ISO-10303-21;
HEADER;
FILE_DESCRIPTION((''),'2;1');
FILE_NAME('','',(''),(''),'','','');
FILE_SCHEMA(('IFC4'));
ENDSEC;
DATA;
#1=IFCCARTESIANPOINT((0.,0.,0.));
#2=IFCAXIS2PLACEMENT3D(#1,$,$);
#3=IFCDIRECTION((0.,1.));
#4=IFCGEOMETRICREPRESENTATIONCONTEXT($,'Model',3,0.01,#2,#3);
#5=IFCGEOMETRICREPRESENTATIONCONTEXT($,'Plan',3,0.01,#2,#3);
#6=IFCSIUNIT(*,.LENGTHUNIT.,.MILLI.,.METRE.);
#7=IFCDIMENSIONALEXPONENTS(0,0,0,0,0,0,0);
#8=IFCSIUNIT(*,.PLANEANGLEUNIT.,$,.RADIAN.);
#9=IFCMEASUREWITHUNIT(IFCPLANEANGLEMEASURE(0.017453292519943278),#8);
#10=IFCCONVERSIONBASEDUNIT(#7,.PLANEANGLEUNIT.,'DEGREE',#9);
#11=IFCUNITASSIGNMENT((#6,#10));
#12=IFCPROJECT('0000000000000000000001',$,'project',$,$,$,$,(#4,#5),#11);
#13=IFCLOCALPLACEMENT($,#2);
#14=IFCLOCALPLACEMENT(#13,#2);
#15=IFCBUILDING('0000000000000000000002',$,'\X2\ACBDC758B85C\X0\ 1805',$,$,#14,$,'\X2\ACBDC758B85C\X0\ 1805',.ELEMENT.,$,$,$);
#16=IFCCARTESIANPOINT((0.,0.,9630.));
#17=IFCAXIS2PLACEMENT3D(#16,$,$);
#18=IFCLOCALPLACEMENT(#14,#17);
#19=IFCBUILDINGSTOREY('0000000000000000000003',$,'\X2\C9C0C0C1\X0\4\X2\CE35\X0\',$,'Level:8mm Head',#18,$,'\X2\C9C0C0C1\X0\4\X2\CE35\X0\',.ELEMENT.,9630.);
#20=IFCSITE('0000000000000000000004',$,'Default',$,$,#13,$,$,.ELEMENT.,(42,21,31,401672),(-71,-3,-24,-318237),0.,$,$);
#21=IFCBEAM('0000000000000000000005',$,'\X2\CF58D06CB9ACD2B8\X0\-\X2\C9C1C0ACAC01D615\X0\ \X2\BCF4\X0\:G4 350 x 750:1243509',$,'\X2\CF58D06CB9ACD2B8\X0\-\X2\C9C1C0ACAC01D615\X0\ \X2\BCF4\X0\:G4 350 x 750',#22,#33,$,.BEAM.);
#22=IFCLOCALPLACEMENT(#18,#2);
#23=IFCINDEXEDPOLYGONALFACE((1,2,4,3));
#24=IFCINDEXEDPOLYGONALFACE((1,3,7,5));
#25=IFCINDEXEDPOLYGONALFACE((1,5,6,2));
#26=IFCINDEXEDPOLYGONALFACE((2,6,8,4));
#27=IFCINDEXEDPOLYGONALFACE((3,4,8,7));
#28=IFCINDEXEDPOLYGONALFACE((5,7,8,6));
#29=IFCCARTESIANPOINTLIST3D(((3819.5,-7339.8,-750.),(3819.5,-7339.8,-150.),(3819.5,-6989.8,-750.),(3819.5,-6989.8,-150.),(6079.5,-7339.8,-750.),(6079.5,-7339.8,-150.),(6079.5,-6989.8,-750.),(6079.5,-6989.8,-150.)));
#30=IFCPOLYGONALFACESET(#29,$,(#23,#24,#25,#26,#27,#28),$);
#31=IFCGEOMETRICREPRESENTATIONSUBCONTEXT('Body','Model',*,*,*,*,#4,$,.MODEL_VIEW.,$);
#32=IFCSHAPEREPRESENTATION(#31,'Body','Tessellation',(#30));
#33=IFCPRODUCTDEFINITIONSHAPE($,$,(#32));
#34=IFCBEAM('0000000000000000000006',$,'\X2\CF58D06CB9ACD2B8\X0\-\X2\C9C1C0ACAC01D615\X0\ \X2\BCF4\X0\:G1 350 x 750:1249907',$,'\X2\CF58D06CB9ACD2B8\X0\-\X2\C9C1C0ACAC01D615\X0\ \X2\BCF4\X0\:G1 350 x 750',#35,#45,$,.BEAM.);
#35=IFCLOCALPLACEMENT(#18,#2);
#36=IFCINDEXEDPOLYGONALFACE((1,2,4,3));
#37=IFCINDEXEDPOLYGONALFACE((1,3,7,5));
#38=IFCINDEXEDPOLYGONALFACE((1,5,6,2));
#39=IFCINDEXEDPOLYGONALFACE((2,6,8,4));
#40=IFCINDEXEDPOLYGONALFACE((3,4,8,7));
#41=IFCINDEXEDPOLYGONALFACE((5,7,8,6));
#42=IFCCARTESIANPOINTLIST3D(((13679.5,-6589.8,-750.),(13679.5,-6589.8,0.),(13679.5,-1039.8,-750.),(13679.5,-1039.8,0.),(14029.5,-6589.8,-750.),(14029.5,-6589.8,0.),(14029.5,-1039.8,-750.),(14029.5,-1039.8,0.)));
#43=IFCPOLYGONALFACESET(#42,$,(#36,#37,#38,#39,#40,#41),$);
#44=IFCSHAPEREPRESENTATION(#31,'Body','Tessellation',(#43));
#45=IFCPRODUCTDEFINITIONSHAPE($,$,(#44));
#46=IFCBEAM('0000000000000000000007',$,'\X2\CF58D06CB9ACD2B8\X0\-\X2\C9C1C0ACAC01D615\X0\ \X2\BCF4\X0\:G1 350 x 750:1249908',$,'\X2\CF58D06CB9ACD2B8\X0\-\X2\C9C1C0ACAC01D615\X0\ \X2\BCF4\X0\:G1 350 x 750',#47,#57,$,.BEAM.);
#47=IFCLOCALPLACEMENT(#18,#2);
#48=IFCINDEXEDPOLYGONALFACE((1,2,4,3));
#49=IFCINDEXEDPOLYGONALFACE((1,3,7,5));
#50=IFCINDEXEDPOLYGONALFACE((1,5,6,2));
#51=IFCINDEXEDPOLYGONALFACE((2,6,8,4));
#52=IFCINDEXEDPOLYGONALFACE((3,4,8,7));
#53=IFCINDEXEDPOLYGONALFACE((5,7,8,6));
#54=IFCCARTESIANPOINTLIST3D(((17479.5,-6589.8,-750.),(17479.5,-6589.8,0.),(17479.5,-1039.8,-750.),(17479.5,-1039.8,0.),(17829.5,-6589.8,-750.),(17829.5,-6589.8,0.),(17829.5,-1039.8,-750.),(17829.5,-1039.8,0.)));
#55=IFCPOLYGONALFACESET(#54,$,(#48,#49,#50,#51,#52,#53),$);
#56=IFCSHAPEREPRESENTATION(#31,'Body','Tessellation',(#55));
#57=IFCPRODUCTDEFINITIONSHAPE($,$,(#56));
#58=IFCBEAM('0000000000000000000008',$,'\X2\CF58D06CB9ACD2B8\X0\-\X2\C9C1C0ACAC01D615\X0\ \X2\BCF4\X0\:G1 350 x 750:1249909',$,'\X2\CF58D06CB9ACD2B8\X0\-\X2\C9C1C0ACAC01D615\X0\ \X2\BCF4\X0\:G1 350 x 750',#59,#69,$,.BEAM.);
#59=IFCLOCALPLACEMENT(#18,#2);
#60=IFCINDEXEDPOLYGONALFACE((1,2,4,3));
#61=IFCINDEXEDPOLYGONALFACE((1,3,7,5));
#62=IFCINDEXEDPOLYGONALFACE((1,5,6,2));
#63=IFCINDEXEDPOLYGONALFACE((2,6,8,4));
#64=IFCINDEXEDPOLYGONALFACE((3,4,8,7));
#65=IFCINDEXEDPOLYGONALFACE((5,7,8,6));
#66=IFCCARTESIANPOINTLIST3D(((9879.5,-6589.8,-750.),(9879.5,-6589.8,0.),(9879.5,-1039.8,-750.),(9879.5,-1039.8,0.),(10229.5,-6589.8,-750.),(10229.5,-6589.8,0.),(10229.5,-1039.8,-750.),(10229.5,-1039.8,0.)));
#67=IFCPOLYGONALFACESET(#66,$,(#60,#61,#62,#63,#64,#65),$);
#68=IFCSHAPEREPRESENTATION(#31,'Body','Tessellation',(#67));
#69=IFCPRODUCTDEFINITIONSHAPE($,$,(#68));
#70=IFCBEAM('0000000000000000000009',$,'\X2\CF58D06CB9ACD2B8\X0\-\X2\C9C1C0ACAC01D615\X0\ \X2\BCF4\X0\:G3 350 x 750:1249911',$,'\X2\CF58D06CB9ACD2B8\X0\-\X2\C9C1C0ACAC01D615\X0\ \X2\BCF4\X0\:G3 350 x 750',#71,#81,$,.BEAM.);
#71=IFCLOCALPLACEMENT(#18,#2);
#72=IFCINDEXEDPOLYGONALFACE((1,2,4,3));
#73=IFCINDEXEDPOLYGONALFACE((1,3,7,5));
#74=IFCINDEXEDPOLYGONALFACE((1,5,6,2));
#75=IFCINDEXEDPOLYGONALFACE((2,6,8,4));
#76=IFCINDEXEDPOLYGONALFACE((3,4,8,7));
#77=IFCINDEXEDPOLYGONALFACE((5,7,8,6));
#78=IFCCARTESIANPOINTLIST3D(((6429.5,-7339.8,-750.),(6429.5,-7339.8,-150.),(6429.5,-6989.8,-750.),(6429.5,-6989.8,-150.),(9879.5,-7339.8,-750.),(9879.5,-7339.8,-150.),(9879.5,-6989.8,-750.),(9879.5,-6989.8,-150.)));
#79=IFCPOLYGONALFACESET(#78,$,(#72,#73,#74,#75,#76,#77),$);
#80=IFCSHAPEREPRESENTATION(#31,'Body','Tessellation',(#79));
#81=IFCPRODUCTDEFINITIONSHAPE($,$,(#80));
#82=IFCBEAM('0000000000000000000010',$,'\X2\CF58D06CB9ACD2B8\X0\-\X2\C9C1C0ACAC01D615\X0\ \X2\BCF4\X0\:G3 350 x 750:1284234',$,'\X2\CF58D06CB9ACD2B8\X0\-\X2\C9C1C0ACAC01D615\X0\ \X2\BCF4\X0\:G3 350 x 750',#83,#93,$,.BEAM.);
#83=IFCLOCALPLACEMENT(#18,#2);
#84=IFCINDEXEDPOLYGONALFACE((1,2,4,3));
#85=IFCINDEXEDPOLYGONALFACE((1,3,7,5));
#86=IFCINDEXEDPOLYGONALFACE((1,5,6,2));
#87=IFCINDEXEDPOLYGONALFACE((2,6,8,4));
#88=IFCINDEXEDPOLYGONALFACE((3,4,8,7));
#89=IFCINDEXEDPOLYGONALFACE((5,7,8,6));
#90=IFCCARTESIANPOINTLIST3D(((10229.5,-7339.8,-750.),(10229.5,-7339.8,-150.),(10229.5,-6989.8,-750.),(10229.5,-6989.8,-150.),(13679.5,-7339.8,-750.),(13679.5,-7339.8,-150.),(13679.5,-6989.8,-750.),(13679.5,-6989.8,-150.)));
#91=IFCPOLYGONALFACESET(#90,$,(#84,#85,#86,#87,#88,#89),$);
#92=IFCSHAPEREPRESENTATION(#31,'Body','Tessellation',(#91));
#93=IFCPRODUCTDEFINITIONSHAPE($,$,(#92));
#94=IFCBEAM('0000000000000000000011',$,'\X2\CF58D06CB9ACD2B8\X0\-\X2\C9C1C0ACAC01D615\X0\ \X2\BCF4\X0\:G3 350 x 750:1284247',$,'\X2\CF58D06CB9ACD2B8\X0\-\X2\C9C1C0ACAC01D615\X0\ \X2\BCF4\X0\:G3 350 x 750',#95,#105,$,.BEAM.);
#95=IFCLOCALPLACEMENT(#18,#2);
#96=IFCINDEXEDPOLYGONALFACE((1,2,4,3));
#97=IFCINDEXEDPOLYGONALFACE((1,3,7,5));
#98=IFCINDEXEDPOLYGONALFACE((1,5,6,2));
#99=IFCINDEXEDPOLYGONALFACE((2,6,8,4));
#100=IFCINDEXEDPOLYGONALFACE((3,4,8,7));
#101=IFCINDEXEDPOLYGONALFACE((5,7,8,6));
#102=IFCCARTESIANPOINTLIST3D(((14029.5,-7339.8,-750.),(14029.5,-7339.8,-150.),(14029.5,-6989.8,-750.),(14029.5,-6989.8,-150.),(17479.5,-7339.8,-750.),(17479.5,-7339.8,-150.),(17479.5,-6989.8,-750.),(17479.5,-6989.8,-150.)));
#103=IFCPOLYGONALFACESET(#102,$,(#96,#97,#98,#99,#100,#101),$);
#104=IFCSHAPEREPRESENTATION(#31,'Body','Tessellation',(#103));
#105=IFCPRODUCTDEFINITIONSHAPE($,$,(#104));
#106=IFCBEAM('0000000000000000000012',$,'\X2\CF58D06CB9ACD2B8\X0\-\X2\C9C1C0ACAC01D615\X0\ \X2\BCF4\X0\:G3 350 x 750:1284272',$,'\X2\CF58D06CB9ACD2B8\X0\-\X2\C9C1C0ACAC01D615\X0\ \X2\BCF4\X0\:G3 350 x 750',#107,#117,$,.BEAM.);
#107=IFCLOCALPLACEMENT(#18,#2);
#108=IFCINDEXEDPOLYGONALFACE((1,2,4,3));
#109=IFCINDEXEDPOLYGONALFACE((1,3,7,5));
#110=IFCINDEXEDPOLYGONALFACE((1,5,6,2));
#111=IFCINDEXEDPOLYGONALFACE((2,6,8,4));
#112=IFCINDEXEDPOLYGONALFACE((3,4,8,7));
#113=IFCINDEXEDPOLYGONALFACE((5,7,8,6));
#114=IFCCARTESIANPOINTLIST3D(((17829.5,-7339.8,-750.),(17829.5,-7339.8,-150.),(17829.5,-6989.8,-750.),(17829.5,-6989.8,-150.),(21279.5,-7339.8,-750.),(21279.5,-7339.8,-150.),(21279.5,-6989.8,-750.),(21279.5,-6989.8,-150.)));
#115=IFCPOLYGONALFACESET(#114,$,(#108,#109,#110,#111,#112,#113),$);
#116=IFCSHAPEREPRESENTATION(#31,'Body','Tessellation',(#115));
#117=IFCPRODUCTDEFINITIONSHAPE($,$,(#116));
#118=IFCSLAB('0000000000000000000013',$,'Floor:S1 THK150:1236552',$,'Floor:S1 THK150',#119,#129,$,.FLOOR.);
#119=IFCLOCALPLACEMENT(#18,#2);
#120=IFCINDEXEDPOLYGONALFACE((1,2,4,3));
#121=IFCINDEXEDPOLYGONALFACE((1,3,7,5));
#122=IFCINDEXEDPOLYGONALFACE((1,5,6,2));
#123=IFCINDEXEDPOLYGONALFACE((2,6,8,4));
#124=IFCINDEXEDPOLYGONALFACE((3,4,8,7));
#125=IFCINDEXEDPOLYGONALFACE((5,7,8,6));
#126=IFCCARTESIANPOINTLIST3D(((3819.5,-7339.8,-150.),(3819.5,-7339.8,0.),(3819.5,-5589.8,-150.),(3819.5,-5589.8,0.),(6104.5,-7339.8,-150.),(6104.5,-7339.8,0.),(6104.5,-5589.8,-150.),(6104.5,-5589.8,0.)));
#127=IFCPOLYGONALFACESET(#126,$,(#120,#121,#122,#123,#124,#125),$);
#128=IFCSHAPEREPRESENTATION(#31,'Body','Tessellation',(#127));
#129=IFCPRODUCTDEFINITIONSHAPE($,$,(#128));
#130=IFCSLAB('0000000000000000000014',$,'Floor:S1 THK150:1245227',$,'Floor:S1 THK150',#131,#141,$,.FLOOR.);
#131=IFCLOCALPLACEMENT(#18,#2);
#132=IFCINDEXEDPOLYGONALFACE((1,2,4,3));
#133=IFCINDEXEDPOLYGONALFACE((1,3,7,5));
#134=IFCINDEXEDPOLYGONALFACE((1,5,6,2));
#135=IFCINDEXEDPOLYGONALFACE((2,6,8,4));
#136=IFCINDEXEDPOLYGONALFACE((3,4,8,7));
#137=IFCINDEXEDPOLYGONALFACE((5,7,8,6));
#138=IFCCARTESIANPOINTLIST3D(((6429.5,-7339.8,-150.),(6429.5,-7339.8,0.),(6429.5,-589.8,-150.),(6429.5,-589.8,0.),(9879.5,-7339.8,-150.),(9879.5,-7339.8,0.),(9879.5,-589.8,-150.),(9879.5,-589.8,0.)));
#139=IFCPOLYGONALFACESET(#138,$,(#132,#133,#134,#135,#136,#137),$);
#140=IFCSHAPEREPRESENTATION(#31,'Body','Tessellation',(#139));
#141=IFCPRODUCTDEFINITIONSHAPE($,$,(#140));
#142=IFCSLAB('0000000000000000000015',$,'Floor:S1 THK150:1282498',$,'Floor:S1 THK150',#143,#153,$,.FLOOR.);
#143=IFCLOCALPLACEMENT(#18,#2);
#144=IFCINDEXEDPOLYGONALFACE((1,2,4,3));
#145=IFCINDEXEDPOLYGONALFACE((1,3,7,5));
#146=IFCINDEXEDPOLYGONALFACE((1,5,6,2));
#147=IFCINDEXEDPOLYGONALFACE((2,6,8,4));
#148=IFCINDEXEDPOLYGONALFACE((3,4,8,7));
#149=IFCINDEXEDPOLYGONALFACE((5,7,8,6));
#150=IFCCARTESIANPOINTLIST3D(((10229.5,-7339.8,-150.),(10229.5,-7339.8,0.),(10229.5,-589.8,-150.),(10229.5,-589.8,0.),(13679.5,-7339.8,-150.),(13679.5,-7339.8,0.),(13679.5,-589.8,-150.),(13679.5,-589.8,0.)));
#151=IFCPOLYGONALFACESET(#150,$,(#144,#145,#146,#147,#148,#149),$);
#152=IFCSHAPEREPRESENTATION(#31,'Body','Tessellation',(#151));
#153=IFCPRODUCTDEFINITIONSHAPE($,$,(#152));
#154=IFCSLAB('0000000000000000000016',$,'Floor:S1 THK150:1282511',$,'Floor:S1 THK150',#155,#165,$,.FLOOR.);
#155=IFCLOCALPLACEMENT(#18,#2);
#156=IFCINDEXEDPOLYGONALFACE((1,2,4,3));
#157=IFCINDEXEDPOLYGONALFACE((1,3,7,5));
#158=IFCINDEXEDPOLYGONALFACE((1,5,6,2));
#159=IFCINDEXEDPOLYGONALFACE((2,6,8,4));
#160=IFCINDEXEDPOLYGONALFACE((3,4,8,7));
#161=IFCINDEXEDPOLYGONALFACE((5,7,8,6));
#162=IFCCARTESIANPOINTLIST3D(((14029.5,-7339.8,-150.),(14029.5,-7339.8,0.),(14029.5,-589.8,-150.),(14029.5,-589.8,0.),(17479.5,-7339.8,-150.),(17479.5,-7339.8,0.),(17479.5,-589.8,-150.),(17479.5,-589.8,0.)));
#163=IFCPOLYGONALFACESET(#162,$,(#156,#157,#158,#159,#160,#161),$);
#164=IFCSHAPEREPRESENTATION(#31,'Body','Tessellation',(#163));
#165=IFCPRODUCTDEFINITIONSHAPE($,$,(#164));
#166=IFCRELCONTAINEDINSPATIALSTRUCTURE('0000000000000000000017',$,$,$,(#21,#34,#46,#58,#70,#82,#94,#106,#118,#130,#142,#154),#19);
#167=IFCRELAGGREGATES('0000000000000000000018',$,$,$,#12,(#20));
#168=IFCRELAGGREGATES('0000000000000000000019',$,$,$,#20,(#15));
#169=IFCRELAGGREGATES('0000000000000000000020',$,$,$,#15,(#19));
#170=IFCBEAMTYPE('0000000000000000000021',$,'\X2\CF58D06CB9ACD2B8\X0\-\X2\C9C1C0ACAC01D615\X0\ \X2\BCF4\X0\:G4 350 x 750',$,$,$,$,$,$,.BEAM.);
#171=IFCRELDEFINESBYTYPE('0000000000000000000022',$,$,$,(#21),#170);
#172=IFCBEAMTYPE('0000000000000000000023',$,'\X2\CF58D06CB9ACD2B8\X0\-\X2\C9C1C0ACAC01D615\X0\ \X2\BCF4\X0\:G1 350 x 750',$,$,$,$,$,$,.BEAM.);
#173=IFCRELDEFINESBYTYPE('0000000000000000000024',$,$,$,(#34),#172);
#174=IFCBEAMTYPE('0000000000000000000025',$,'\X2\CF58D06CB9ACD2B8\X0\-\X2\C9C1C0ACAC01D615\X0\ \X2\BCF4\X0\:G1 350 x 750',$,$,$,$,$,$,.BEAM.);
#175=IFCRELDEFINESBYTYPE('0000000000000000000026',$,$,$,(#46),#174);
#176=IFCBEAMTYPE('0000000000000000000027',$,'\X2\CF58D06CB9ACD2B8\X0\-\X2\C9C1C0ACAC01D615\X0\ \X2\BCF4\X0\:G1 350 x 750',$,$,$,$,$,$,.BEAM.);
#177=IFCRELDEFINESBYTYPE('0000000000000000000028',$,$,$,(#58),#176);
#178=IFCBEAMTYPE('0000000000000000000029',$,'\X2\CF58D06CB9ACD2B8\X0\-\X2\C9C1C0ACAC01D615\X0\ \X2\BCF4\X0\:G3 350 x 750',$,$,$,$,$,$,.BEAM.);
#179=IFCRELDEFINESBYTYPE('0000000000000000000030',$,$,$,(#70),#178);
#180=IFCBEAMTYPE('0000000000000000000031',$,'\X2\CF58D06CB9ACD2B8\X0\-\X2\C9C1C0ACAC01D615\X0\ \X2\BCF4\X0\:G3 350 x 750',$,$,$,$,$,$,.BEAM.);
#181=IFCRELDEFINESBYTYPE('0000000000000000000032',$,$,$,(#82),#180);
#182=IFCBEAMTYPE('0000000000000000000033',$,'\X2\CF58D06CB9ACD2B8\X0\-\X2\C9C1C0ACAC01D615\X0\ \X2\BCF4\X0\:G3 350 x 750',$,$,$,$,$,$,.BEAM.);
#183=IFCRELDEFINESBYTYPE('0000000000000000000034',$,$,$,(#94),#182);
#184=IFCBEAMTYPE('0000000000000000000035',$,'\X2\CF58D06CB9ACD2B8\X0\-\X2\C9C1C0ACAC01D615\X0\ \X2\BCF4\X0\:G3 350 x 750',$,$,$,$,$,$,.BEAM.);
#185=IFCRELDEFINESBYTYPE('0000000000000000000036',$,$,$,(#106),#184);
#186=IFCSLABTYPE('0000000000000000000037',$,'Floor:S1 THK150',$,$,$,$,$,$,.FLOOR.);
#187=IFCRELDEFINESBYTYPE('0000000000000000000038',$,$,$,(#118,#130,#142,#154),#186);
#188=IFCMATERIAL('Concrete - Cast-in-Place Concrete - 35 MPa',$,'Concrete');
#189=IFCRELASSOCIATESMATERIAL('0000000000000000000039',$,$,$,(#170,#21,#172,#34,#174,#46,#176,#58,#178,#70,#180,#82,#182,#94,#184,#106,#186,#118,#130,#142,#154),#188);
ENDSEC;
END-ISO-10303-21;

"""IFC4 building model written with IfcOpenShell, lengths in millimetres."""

from ifc_helpers import new_model, entity, si_unit, converted_unit, direction, frame, origin, place, context, subcontext, project, spatial, indexed_curve, outline, extrude, source, transform, mapped, material, type_object, type_shapes, element, save


model = new_model("IFC4")

# Units and contexts
model_context = context("Model", 3, precision=0.01, world=origin(), true_north=direction((0.0, 1.0)))
plan_context = context("Plan", 3, precision=0.01, world=origin(), true_north=direction((0.0, 1.0)))
body_context = subcontext(model_context, "Body", "Model", "MODEL_VIEW")
ifc_project = project(units=[si_unit("LENGTHUNIT", "METRE", prefix="MILLI"), converted_unit("PLANEANGLEUNIT", "DEGREE", entity("IfcPlaneAngleMeasure", 0.017453292519943278), si_unit("PLANEANGLEUNIT", "RADIAN"), dimensions=[0, 0, 0, 0, 0, 0, 0])], contexts=[model_context, plan_context])

# Site, building, storey
site_placement = place(None, origin())
site = spatial("IfcSite", under=ifc_project, at=site_placement, Name="Default", CompositionType="ELEMENT", RefLatitude=(42, 21, 31, 401672), RefLongitude=(-71, -3, -24, -318237), RefElevation=0.0)
building_placement = place(site_placement, origin())
building = spatial("IfcBuilding", under=site, at=building_placement, Name="경의로 1805", LongName="경의로 1805", CompositionType="ELEMENT")
storey_placement = place(building_placement, frame((0.0, 0.0, 9630.0)))
storey = spatial("IfcBuildingStorey", under=building, at=storey_placement, Name="지상4층", ObjectType="Level:8mm Head", LongName="지상4층", CompositionType="ELEMENT", Elevation=9630.0)

# Beams
ifc_material_1 = material(Name="Concrete - Cast-in-Place Concrete - 35 MPa", Category="Concrete")
beam_type_1 = type_object("IfcBeamType", Name="콘크리트-직사각형 보:G4 350 x 750", PredefinedType="BEAM", material=ifc_material_1)
shared_shape_1 = source(origin(), body_context, "Body", "SweptSolid", [
    extrude(outline(indexed_curve([(-300.0, -175.0), (300.0, -175.0), (300.0, 175.0), (-300.0, 175.0), (-300.0, -175.0)], self_intersect=False)), frame((3819.5, -7164.8, 9180.0), z_axis=(1.0, 0.0, 0.0), x_axis=(0.0, 0.0, -1.0)), (0.0, 0.0, 1.0), 2260.0),
])
type_shapes(beam_type_1, [shared_shape_1])
beam_1_placement = place(storey_placement, frame((0.0, 0.0, -9630.0)))
element("IfcBeam", 1, at=beam_1_placement, inside=storey, type_object=beam_type_1, material=ifc_material_1, Name="콘크리트-직사각형 보:G4 350 x 750:1243509", ObjectType="콘크리트-직사각형 보:G4 350 x 750", PredefinedType="BEAM", context=body_context, shape_type="MappedRepresentation", body=[
    mapped(shared_shape_1, transform((0.0, 0.0, 0.0), scale=1.0)),
])
beam_type_2 = type_object("IfcBeamType", Name="콘크리트-직사각형 보:G1 350 x 750", PredefinedType="BEAM", material=ifc_material_1)
shared_shape_2 = source(origin(), body_context, "Body", "SweptSolid", [
    extrude(outline(indexed_curve([(-175.0, -375.0), (175.0, -375.0), (175.0, 375.0), (-175.0, 375.0), (-175.0, -375.0)], self_intersect=False)), frame((13854.5, -1039.8, 9255.0), z_axis=(0.0, -1.0, 0.0), x_axis=(-1.0, 0.0, 0.0)), (0.0, 0.0, 1.0), 5550.0),
])
type_shapes(beam_type_2, [shared_shape_2])
beam_2_placement = place(storey_placement, frame((0.0, 0.0, -9630.0)))
element("IfcBeam", 2, at=beam_2_placement, inside=storey, type_object=beam_type_2, material=ifc_material_1, Name="콘크리트-직사각형 보:G1 350 x 750:1249907", ObjectType="콘크리트-직사각형 보:G1 350 x 750", PredefinedType="BEAM", context=body_context, shape_type="MappedRepresentation", body=[
    mapped(shared_shape_2, transform((0.0, 0.0, 0.0), scale=1.0)),
])
beam_type_3 = type_object("IfcBeamType", Name="콘크리트-직사각형 보:G1 350 x 750", PredefinedType="BEAM", material=ifc_material_1)
shared_shape_3 = source(origin(), body_context, "Body", "SweptSolid", [
    extrude(outline(indexed_curve([(-175.0, -375.0), (175.0, -375.0), (175.0, 375.0), (-175.0, 375.0), (-175.0, -375.0)], self_intersect=False)), frame((17654.5, -1039.8, 9255.0), z_axis=(0.0, -1.0, 0.0), x_axis=(-1.0, 0.0, 0.0)), (0.0, 0.0, 1.0), 5550.0),
])
type_shapes(beam_type_3, [shared_shape_3])
beam_3_placement = place(storey_placement, frame((0.0, 0.0, -9630.0)))
element("IfcBeam", 3, at=beam_3_placement, inside=storey, type_object=beam_type_3, material=ifc_material_1, Name="콘크리트-직사각형 보:G1 350 x 750:1249908", ObjectType="콘크리트-직사각형 보:G1 350 x 750", PredefinedType="BEAM", context=body_context, shape_type="MappedRepresentation", body=[
    mapped(shared_shape_3, transform((0.0, 0.0, 0.0), scale=1.0)),
])
beam_type_4 = type_object("IfcBeamType", Name="콘크리트-직사각형 보:G1 350 x 750", PredefinedType="BEAM", material=ifc_material_1)
shared_shape_4 = source(origin(), body_context, "Body", "SweptSolid", [
    extrude(outline(indexed_curve([(-175.0, -375.0), (175.0, -375.0), (175.0, 375.0), (-175.0, 375.0), (-175.0, -375.0)], self_intersect=False)), frame((10054.5, -1039.8, 9255.0), z_axis=(0.0, -1.0, 0.0), x_axis=(-1.0, 0.0, 0.0)), (0.0, 0.0, 1.0), 5550.0),
])
type_shapes(beam_type_4, [shared_shape_4])
beam_4_placement = place(storey_placement, frame((0.0, 0.0, -9630.0)))
element("IfcBeam", 4, at=beam_4_placement, inside=storey, type_object=beam_type_4, material=ifc_material_1, Name="콘크리트-직사각형 보:G1 350 x 750:1249909", ObjectType="콘크리트-직사각형 보:G1 350 x 750", PredefinedType="BEAM", context=body_context, shape_type="MappedRepresentation", body=[
    mapped(shared_shape_4, transform((0.0, 0.0, 0.0), scale=1.0)),
])
beam_type_5 = type_object("IfcBeamType", Name="콘크리트-직사각형 보:G3 350 x 750", PredefinedType="BEAM", material=ifc_material_1)
shared_shape_5 = source(origin(), body_context, "Body", "SweptSolid", [
    extrude(outline(indexed_curve([(-300.0, -175.0), (300.0, -175.0), (300.0, 175.0), (-300.0, 175.0), (-300.0, -175.0)], self_intersect=False)), frame((6429.5, -7164.8, 9180.0), z_axis=(1.0, 0.0, 0.0), x_axis=(0.0, 0.0, -1.0)), (0.0, 0.0, 1.0), 3450.0),
])
type_shapes(beam_type_5, [shared_shape_5])
beam_5_placement = place(storey_placement, frame((0.0, 0.0, -9630.0)))
element("IfcBeam", 5, at=beam_5_placement, inside=storey, type_object=beam_type_5, material=ifc_material_1, Name="콘크리트-직사각형 보:G3 350 x 750:1249911", ObjectType="콘크리트-직사각형 보:G3 350 x 750", PredefinedType="BEAM", context=body_context, shape_type="MappedRepresentation", body=[
    mapped(shared_shape_5, transform((0.0, 0.0, 0.0), scale=1.0)),
])
beam_type_6 = type_object("IfcBeamType", Name="콘크리트-직사각형 보:G3 350 x 750", PredefinedType="BEAM", material=ifc_material_1)
shared_shape_6 = source(origin(), body_context, "Body", "SweptSolid", [
    extrude(outline(indexed_curve([(-300.0, -175.0), (300.0, -175.0), (300.0, 175.0), (-300.0, 175.0), (-300.0, -175.0)], self_intersect=False)), frame((10229.5, -7164.8, 9180.0), z_axis=(1.0, 0.0, 0.0), x_axis=(0.0, 0.0, -1.0)), (0.0, 0.0, 1.0), 3450.0),
])
type_shapes(beam_type_6, [shared_shape_6])
beam_6_placement = place(storey_placement, frame((0.0, 0.0, -9630.0)))
element("IfcBeam", 6, at=beam_6_placement, inside=storey, type_object=beam_type_6, material=ifc_material_1, Name="콘크리트-직사각형 보:G3 350 x 750:1284234", ObjectType="콘크리트-직사각형 보:G3 350 x 750", PredefinedType="BEAM", context=body_context, shape_type="MappedRepresentation", body=[
    mapped(shared_shape_6, transform((0.0, 0.0, 0.0), scale=1.0)),
])
beam_type_7 = type_object("IfcBeamType", Name="콘크리트-직사각형 보:G3 350 x 750", PredefinedType="BEAM", material=ifc_material_1)
shared_shape_7 = source(origin(), body_context, "Body", "SweptSolid", [
    extrude(outline(indexed_curve([(-300.0, -175.0), (300.0, -175.0), (300.0, 175.0), (-300.0, 175.0), (-300.0, -175.0)], self_intersect=False)), frame((14029.5, -7164.8, 9180.0), z_axis=(1.0, 0.0, 0.0), x_axis=(0.0, 0.0, -1.0)), (0.0, 0.0, 1.0), 3450.0),
])
type_shapes(beam_type_7, [shared_shape_7])
beam_7_placement = place(storey_placement, frame((0.0, 0.0, -9630.0)))
element("IfcBeam", 7, at=beam_7_placement, inside=storey, type_object=beam_type_7, material=ifc_material_1, Name="콘크리트-직사각형 보:G3 350 x 750:1284247", ObjectType="콘크리트-직사각형 보:G3 350 x 750", PredefinedType="BEAM", context=body_context, shape_type="MappedRepresentation", body=[
    mapped(shared_shape_7, transform((0.0, 0.0, 0.0), scale=1.0)),
])
beam_type_8 = type_object("IfcBeamType", Name="콘크리트-직사각형 보:G3 350 x 750", PredefinedType="BEAM", material=ifc_material_1)
shared_shape_8 = source(origin(), body_context, "Body", "SweptSolid", [
    extrude(outline(indexed_curve([(-300.0, -175.0), (300.0, -175.0), (300.0, 175.0), (-300.0, 175.0), (-300.0, -175.0)], self_intersect=False)), frame((17829.5, -7164.8, 9180.0), z_axis=(1.0, 0.0, 0.0), x_axis=(0.0, 0.0, -1.0)), (0.0, 0.0, 1.0), 3450.0),
])
type_shapes(beam_type_8, [shared_shape_8])
beam_8_placement = place(storey_placement, frame((0.0, 0.0, -9630.0)))
element("IfcBeam", 8, at=beam_8_placement, inside=storey, type_object=beam_type_8, material=ifc_material_1, Name="콘크리트-직사각형 보:G3 350 x 750:1284272", ObjectType="콘크리트-직사각형 보:G3 350 x 750", PredefinedType="BEAM", context=body_context, shape_type="MappedRepresentation", body=[
    mapped(shared_shape_8, transform((0.0, 0.0, 0.0), scale=1.0)),
])

# Slabs
slab_type_1 = type_object("IfcSlabType", Name="Floor:S1 THK150", PredefinedType="FLOOR", material=ifc_material_1)
slab_1_placement = place(storey_placement, origin())
element("IfcSlab", 9, at=slab_1_placement, inside=storey, type_object=slab_type_1, material=ifc_material_1, Name="Floor:S1 THK150:1236552", ObjectType="Floor:S1 THK150", PredefinedType="FLOOR", context=body_context, shape_type="SweptSolid", body=[
    extrude(outline(indexed_curve([(-875.0, -1142.5), (875.0, -1142.5), (875.0, 1142.5), (-875.0, 1142.5), (-875.0, -1142.5)], self_intersect=False)), frame((4962.0, -6464.8, 0.0), z_axis=(0.0, 0.0, -1.0), x_axis=(0.0, 1.0, 0.0)), (0.0, 0.0, 1.0), 150.0),
])
slab_2_placement = place(storey_placement, origin())
element("IfcSlab", 10, at=slab_2_placement, inside=storey, type_object=slab_type_1, material=ifc_material_1, Name="Floor:S1 THK150:1245227", ObjectType="Floor:S1 THK150", PredefinedType="FLOOR", context=body_context, shape_type="SweptSolid", body=[
    extrude(outline(indexed_curve([(-3375.0, -1725.0), (3375.0, -1725.0), (3375.0, 1725.0), (-3375.0, 1725.0), (-3375.0, -1725.0)], self_intersect=False)), frame((8154.5, -3964.8, 0.0), z_axis=(0.0, 0.0, -1.0), x_axis=(0.0, 1.0, 0.0)), (0.0, 0.0, 1.0), 150.0),
])
slab_3_placement = place(storey_placement, origin())
element("IfcSlab", 11, at=slab_3_placement, inside=storey, type_object=slab_type_1, material=ifc_material_1, Name="Floor:S1 THK150:1282498", ObjectType="Floor:S1 THK150", PredefinedType="FLOOR", context=body_context, shape_type="SweptSolid", body=[
    extrude(outline(indexed_curve([(-3375.0, -1725.0), (3375.0, -1725.0), (3375.0, 1725.0), (-3375.0, 1725.0), (-3375.0, -1725.0)], self_intersect=False)), frame((11954.5, -3964.8, 0.0), z_axis=(0.0, 0.0, -1.0), x_axis=(0.0, 1.0, 0.0)), (0.0, 0.0, 1.0), 150.0),
])
slab_4_placement = place(storey_placement, origin())
element("IfcSlab", 12, at=slab_4_placement, inside=storey, type_object=slab_type_1, material=ifc_material_1, Name="Floor:S1 THK150:1282511", ObjectType="Floor:S1 THK150", PredefinedType="FLOOR", context=body_context, shape_type="SweptSolid", body=[
    extrude(outline(indexed_curve([(-3375.0, -1725.0), (3375.0, -1725.0), (3375.0, 1725.0), (-3375.0, 1725.0), (-3375.0, -1725.0)], self_intersect=False)), frame((15754.5, -3964.8, 0.0), z_axis=(0.0, 0.0, -1.0), x_axis=(0.0, 1.0, 0.0)), (0.0, 0.0, 1.0), 150.0),
])

save(model, "model.ifc")
